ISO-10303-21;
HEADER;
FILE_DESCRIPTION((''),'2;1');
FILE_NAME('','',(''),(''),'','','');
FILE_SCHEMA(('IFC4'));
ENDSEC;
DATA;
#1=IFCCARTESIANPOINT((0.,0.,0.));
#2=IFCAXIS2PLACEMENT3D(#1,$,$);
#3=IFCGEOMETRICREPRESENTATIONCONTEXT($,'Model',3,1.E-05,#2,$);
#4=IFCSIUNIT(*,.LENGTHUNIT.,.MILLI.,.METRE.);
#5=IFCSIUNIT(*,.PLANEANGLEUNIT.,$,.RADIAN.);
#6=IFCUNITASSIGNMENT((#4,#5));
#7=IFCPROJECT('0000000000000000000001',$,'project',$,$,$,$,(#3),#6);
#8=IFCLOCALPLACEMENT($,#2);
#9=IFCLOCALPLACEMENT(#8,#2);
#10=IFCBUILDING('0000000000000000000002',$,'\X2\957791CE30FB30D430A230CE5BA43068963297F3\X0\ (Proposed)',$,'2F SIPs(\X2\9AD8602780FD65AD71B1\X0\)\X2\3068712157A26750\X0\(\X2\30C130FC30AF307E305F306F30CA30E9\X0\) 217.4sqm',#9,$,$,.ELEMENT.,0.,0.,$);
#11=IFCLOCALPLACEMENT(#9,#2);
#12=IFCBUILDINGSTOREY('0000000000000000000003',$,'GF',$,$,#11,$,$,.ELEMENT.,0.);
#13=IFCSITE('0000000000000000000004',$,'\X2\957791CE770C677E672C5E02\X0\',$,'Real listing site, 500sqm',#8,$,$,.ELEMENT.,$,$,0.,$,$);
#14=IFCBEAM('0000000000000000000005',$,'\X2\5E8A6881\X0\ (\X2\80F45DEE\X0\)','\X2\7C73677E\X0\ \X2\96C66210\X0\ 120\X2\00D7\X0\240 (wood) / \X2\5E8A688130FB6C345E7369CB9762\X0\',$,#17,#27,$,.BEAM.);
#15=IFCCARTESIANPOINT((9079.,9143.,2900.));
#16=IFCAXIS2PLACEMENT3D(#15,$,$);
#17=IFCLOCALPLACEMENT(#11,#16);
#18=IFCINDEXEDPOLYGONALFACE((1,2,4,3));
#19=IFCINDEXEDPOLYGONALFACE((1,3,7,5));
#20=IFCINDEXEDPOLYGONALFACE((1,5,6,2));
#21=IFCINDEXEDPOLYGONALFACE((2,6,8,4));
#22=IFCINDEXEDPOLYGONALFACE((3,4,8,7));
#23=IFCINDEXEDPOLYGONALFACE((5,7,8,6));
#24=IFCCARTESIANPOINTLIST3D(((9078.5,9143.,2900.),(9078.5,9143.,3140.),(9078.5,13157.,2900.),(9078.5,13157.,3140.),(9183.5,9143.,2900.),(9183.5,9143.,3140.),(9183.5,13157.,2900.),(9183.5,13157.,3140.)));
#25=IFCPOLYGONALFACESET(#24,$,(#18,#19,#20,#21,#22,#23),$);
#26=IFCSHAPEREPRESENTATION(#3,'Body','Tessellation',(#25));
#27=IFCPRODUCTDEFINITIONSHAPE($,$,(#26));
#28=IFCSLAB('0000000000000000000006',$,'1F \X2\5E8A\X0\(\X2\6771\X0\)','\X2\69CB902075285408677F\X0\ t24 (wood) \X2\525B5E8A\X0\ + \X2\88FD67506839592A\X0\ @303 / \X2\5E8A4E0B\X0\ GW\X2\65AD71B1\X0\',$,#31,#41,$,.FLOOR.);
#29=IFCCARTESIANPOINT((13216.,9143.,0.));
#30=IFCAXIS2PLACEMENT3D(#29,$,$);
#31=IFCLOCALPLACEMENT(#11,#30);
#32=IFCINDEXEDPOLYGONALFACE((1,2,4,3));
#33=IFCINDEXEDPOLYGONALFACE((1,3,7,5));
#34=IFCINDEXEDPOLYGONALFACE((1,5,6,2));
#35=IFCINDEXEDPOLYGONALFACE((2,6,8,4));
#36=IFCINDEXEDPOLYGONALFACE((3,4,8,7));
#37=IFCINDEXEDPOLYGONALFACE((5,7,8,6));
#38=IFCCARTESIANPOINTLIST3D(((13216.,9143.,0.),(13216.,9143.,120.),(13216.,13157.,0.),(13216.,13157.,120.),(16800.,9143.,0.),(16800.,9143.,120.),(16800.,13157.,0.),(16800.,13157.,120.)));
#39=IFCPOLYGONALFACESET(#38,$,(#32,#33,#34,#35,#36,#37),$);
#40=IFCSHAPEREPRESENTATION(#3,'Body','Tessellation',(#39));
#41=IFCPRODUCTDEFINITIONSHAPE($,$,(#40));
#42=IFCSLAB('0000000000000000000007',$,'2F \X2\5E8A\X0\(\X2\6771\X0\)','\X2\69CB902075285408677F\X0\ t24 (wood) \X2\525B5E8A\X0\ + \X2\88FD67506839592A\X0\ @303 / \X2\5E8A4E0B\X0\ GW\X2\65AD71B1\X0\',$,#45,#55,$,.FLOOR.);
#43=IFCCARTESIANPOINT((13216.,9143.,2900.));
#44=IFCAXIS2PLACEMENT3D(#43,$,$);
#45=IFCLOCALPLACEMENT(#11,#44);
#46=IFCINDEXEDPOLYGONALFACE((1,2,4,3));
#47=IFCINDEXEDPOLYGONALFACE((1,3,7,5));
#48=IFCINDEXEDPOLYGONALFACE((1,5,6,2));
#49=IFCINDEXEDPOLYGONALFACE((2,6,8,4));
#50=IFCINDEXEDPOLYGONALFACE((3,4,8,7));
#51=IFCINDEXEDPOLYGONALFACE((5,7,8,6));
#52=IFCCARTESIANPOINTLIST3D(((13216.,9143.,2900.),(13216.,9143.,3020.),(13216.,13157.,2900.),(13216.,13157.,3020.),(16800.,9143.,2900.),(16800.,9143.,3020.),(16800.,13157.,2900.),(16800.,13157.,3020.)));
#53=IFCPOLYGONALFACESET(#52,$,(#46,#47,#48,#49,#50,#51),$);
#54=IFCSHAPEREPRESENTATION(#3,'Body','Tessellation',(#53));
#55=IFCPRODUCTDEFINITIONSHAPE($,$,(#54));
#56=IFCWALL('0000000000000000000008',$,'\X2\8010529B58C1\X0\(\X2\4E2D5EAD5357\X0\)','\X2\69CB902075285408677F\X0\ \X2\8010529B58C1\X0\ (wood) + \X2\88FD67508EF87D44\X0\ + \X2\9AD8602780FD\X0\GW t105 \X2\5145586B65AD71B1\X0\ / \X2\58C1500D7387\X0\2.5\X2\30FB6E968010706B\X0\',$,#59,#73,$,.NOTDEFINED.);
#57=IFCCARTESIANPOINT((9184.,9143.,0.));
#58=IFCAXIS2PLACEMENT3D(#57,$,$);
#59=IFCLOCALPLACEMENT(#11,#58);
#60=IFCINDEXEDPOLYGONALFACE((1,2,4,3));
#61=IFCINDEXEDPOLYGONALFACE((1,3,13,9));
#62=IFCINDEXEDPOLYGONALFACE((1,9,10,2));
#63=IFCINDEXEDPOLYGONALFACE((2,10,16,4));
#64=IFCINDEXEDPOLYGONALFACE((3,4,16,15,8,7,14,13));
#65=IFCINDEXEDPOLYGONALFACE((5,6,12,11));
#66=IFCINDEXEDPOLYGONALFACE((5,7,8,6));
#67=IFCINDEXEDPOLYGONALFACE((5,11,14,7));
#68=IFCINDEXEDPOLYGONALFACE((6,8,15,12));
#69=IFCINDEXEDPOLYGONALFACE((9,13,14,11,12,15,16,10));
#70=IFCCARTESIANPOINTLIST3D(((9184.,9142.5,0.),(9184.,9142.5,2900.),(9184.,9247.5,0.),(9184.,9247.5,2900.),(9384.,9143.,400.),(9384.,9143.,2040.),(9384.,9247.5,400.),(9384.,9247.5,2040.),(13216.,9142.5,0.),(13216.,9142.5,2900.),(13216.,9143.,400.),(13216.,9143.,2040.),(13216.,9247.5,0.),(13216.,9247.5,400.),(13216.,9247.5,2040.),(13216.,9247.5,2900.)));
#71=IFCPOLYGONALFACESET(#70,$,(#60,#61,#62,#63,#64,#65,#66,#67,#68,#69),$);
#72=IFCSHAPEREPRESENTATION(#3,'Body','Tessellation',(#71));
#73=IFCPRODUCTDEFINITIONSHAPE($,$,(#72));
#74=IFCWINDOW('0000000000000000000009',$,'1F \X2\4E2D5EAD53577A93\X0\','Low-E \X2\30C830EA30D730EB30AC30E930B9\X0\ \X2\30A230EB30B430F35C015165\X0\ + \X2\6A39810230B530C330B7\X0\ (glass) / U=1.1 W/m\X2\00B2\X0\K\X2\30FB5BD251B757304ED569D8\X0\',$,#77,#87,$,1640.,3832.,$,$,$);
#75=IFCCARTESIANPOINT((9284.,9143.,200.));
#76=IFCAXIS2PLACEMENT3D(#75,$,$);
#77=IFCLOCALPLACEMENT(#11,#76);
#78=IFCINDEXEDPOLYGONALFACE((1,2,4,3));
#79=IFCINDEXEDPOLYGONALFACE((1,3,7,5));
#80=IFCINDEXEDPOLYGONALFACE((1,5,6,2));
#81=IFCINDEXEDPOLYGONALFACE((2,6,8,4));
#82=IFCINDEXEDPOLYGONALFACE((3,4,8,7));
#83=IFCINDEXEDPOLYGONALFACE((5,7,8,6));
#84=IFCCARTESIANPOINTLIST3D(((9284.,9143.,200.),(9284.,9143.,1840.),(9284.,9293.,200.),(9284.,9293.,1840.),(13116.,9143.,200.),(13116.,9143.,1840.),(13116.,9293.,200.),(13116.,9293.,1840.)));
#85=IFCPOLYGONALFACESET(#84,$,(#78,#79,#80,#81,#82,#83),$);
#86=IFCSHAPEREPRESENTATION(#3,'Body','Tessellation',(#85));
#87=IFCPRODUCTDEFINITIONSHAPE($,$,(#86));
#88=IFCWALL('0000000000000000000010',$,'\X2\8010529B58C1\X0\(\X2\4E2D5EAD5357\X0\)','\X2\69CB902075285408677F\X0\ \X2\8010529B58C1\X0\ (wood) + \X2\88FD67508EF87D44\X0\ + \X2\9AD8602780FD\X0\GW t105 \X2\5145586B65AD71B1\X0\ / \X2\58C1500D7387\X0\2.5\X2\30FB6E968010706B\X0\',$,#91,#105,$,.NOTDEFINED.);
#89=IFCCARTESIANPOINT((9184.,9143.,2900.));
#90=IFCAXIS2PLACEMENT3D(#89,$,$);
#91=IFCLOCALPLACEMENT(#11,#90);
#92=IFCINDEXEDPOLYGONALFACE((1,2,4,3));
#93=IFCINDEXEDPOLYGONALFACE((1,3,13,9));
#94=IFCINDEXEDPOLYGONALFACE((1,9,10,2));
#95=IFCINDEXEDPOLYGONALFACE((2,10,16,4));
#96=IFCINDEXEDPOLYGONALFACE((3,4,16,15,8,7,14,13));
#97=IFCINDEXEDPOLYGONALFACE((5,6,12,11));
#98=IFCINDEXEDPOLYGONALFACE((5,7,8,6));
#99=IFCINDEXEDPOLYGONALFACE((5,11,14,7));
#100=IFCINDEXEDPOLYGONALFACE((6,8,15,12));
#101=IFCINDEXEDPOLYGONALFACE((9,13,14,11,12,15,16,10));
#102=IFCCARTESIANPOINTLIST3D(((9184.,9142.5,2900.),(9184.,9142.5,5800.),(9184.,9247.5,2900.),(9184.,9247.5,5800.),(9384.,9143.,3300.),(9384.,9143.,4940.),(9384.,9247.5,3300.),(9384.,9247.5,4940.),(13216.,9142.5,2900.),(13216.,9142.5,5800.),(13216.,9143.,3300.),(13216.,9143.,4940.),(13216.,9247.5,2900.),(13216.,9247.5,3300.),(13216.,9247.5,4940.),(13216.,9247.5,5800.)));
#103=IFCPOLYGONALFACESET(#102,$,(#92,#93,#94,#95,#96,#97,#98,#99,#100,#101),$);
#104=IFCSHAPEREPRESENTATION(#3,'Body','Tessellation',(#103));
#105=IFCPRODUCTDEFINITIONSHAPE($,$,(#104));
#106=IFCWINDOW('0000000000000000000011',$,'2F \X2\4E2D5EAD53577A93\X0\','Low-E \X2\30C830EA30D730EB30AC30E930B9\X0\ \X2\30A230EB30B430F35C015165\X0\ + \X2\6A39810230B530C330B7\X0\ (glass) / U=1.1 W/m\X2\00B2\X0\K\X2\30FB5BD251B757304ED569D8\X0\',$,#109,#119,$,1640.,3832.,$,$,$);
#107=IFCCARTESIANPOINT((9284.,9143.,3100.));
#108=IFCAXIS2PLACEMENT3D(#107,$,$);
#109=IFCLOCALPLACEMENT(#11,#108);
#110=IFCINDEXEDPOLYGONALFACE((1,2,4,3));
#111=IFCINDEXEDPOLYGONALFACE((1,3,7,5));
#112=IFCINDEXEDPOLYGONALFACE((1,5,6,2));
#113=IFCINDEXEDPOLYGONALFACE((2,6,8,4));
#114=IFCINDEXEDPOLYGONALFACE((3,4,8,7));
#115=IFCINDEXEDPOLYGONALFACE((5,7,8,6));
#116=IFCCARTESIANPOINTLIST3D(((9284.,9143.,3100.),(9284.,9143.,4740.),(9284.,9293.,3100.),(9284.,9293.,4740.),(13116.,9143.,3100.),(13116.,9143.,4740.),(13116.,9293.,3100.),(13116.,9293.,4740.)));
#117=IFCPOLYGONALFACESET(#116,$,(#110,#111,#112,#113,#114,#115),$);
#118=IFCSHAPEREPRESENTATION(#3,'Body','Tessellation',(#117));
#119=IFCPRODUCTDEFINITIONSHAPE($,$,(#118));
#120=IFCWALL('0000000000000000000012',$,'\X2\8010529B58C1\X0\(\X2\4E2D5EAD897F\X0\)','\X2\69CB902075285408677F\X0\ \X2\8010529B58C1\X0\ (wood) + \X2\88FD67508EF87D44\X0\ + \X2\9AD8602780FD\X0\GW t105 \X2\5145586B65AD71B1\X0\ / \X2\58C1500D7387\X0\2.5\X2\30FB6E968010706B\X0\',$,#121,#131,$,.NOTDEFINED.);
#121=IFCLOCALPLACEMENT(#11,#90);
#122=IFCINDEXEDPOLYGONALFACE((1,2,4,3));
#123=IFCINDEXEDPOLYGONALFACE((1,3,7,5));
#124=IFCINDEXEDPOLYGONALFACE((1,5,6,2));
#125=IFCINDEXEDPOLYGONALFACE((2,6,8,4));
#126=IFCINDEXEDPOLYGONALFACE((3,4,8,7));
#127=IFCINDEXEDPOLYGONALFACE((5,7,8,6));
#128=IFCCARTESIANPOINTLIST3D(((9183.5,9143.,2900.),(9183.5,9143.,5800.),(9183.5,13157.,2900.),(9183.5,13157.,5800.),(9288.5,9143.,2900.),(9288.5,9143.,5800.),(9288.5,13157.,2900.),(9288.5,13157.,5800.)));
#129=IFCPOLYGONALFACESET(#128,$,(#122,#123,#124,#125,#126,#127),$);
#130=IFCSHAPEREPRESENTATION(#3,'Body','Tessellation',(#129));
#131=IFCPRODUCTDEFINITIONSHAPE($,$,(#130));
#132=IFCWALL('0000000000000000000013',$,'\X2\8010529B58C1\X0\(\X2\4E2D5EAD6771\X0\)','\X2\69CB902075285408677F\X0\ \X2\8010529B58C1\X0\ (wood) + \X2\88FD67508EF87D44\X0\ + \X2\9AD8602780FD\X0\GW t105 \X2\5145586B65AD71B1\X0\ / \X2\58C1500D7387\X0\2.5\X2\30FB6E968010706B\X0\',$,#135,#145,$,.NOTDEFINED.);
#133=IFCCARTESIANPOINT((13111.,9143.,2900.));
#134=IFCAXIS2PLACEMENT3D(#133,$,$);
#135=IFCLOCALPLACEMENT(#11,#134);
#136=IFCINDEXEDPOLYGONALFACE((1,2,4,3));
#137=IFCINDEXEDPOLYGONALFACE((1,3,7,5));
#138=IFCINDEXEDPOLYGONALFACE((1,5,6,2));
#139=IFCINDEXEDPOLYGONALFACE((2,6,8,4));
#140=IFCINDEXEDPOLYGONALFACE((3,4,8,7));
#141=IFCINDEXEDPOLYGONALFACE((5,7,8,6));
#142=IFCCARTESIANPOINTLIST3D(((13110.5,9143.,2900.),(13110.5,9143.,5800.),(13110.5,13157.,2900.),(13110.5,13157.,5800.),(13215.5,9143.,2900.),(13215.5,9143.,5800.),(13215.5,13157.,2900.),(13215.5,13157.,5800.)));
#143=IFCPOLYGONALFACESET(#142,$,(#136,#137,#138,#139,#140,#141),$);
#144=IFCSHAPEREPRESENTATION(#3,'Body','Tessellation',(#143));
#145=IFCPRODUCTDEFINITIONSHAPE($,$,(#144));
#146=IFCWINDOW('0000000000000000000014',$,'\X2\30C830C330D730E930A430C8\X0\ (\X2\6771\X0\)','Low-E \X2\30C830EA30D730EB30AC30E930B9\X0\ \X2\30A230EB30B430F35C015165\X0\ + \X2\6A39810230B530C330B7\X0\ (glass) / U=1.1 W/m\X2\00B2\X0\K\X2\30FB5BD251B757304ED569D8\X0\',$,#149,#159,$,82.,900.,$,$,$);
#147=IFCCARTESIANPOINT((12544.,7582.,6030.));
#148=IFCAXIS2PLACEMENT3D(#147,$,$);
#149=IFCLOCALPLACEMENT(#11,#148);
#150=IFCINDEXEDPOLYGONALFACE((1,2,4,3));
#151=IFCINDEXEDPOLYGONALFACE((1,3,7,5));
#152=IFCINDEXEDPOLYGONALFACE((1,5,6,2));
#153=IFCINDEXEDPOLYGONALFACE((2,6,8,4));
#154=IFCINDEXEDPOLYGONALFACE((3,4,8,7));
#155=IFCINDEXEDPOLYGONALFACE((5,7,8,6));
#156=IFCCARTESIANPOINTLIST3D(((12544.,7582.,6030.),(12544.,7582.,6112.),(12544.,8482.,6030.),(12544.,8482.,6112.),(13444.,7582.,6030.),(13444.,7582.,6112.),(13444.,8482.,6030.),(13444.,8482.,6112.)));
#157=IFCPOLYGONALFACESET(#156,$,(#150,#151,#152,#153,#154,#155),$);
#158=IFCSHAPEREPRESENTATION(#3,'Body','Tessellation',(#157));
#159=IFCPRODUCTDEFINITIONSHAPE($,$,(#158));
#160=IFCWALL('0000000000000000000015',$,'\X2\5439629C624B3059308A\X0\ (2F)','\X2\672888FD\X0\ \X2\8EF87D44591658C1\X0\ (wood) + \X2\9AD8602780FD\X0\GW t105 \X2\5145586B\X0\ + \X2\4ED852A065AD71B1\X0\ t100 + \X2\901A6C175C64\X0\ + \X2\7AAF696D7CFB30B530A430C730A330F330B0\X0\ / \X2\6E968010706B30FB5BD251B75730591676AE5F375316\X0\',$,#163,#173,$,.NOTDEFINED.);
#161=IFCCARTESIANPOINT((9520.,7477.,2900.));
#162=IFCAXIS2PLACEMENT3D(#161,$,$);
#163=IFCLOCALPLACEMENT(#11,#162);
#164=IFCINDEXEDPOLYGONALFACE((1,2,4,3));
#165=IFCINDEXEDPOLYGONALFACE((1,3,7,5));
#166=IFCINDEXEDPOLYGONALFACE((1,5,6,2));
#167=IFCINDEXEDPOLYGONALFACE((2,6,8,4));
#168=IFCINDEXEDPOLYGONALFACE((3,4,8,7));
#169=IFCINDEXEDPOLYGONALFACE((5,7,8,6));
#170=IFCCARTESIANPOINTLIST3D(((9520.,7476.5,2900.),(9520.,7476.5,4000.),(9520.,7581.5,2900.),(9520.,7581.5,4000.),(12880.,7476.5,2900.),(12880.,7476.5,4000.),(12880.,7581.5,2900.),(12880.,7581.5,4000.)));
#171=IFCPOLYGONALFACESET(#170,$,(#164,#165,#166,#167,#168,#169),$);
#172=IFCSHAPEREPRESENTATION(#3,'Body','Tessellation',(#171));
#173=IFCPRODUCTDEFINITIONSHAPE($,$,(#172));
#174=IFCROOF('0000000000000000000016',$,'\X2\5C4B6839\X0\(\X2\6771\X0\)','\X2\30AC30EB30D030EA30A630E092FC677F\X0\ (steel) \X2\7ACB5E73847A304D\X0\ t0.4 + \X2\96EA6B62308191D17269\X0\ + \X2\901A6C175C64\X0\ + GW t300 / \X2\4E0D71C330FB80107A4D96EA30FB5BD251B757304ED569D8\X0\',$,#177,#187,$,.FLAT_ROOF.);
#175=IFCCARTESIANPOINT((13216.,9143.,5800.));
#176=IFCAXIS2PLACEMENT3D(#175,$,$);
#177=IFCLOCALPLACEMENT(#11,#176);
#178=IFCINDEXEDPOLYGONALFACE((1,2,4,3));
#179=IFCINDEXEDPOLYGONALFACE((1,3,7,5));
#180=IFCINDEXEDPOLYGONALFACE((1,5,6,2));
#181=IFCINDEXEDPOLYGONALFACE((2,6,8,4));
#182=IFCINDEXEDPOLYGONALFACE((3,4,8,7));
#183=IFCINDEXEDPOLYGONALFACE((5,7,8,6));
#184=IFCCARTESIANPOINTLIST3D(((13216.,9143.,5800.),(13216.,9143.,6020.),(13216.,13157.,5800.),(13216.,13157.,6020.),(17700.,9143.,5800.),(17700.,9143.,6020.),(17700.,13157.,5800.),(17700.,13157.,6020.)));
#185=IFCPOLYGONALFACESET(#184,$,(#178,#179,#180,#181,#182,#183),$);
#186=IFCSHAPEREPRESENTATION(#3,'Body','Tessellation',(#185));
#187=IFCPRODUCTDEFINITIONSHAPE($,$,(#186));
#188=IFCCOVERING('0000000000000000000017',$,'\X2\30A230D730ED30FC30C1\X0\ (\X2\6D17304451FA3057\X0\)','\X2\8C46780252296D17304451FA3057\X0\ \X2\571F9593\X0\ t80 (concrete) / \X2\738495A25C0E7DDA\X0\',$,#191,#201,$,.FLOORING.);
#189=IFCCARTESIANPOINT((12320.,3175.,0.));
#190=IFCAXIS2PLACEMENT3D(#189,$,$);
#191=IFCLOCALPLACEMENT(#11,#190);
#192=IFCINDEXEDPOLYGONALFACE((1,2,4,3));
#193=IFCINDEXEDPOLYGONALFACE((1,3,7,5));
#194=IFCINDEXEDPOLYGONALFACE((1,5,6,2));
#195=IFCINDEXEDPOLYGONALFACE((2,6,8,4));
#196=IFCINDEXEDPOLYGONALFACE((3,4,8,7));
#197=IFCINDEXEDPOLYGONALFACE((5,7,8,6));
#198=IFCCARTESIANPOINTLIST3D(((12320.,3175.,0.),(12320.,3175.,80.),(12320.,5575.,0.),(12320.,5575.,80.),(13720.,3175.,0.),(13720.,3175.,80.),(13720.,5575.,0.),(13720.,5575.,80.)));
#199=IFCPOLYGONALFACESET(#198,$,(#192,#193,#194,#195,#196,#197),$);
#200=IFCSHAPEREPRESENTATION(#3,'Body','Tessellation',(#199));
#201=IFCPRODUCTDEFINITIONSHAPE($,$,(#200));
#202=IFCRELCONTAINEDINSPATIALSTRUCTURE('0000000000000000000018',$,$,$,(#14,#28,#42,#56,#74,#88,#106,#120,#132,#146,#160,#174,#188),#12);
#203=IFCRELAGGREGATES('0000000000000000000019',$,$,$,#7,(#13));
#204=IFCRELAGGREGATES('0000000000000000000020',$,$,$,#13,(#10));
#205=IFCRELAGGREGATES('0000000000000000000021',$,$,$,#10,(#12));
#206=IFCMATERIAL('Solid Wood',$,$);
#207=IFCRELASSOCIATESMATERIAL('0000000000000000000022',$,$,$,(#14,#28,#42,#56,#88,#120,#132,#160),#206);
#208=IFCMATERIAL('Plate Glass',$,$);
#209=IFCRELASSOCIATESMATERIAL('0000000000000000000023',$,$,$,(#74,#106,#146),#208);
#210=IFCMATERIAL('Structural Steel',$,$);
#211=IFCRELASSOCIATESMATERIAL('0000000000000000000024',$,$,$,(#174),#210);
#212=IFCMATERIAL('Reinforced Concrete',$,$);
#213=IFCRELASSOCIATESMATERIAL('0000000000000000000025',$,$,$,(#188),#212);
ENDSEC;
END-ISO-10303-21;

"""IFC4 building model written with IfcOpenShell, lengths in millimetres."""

from ifc_helpers import new_model, si_unit, frame, frame_2d, origin, place, context, project, spatial, rectangle, extrude, material, element, fill, save


model = new_model("IFC4")

# Units and contexts
model_context = context("Model", 3, precision=1e-05, world=origin())
ifc_project = project(units=[si_unit("LENGTHUNIT", "METRE", prefix="MILLI"), si_unit("PLANEANGLEUNIT", "RADIAN")], contexts=[model_context])

# Site, building, storey
site_placement = place(None, origin())
site = spatial("IfcSite", under=ifc_project, at=site_placement, Name="長野県松本市", ObjectType="Real listing site, 500sqm", CompositionType="ELEMENT", RefElevation=0.0)
building_placement = place(site_placement, origin())
building = spatial("IfcBuilding", under=site, at=building_placement, Name="長野・ピアノ室と防音 (Proposed)", ObjectType="2F SIPs(高性能断熱)と無垢材(チークまたはナラ) 217.4sqm", CompositionType="ELEMENT", ElevationOfRefHeight=0.0, ElevationOfTerrain=0.0)
storey_placement = place(building_placement, origin())
storey = spatial("IfcBuildingStorey", under=building, at=storey_placement, Name="GF", CompositionType="ELEMENT", Elevation=0.0)

# Shared definitions
ifc_material_1 = material(Name="Solid Wood")

# Beam
beam_placement = place(storey_placement, frame((9079.0, 9143.0, 2900.0)))
element("IfcBeam", 1, at=beam_placement, inside=storey, material=ifc_material_1, Name="床梁 (胴差)", Description="米松 集成 120×240 (wood) / 床梁・水平構面", PredefinedType="BEAM", context=model_context, shape_type="SweptSolid", body=[
    extrude(rectangle(XDim=105.0, YDim=4014.0, at=frame_2d((52.0, 2007.0))), frame((9079.0, 9143.0, 2900.0)), (0.0, 0.0, 1.0), 240.0),
])

# Slabs
slab_1_placement = place(storey_placement, frame((13216.0, 9143.0, 0.0)))
element("IfcSlab", 2, at=slab_1_placement, inside=storey, material=ifc_material_1, Name="1F 床(東)", Description="構造用合板 t24 (wood) 剛床 + 製材根太 @303 / 床下 GW断熱", PredefinedType="FLOOR", context=model_context, shape_type="SweptSolid", body=[
    extrude(rectangle(XDim=3584.0, YDim=4014.0, at=frame_2d((1792.0, 2007.0))), frame((13216.0, 9143.0, 0.0)), (0.0, 0.0, 1.0), 120.0),
])
slab_2_placement = place(storey_placement, frame((13216.0, 9143.0, 2900.0)))
element("IfcSlab", 3, at=slab_2_placement, inside=storey, material=ifc_material_1, Name="2F 床(東)", Description="構造用合板 t24 (wood) 剛床 + 製材根太 @303 / 床下 GW断熱", PredefinedType="FLOOR", context=model_context, shape_type="SweptSolid", body=[
    extrude(rectangle(XDim=3584.0, YDim=4014.0, at=frame_2d((1792.0, 2007.0))), frame((13216.0, 9143.0, 2900.0)), (0.0, 0.0, 1.0), 120.0),
])

# Wall, opening, window
wall_1_placement = place(storey_placement, frame((9184.0, 9143.0, 0.0)))
wall_1 = element("IfcWall", 4, at=wall_1_placement, inside=storey, material=ifc_material_1, Name="耐力壁(中庭南)", Description="構造用合板 耐力壁 (wood) + 製材軸組 + 高性能GW t105 充填断熱 / 壁倍率2.5・準耐火", PredefinedType="NOTDEFINED", context=model_context, shape_type="SweptSolid", body=[
    extrude(rectangle(XDim=4032.0, YDim=105.0, at=frame_2d((2016.0, 52.0))), frame((9184.0, 9143.0, 0.0)), (0.0, 0.0, 1.0), 2900.0),
])
opening_1_placement = place(storey_placement, frame((9284.0, 9143.0, 200.0)))
opening_1 = element("IfcOpeningElement", 5, at=opening_1_placement, cuts=wall_1, PredefinedType="NOTDEFINED", context=model_context, shape_type="SweptSolid", body=[
    extrude(rectangle(XDim=3832.0, YDim=150.0, at=frame_2d((1916.0, 75.0))), frame((9284.0, 9143.0, 200.0)), (0.0, 0.0, 1.0), 1640.0),
])
ifc_material_2 = material(Name="Plate Glass")
window_1_placement = place(storey_placement, frame((9284.0, 9143.0, 200.0)))
window_1 = element("IfcWindow", 6, at=window_1_placement, inside=storey, material=ifc_material_2, Name="1F 中庭南窓", Description="Low-E トリプルガラス アルゴン封入 + 樹脂サッシ (glass) / U=1.1 W/m²K・寒冷地仕様", OverallHeight=1640.0, OverallWidth=3832.0, context=model_context, shape_type="SweptSolid", body=[
    extrude(rectangle(XDim=3832.0, YDim=150.0, at=frame_2d((1916.0, 75.0))), frame((9284.0, 9143.0, 200.0)), (0.0, 0.0, 1.0), 1640.0),
])
fill(opening_1, window_1)

# Wall, opening, window
wall_2_placement = place(storey_placement, frame((9184.0, 9143.0, 2900.0)))
wall_2 = element("IfcWall", 7, at=wall_2_placement, inside=storey, material=ifc_material_1, Name="耐力壁(中庭南)", Description="構造用合板 耐力壁 (wood) + 製材軸組 + 高性能GW t105 充填断熱 / 壁倍率2.5・準耐火", PredefinedType="NOTDEFINED", context=model_context, shape_type="SweptSolid", body=[
    extrude(rectangle(XDim=4032.0, YDim=105.0, at=frame_2d((2016.0, 52.0))), frame((9184.0, 9143.0, 2900.0)), (0.0, 0.0, 1.0), 2900.0),
])
opening_2_placement = place(storey_placement, frame((9284.0, 9143.0, 3100.0)))
opening_2 = element("IfcOpeningElement", 8, at=opening_2_placement, cuts=wall_2, PredefinedType="NOTDEFINED", context=model_context, shape_type="SweptSolid", body=[
    extrude(rectangle(XDim=3832.0, YDim=150.0, at=frame_2d((1916.0, 75.0))), frame((9284.0, 9143.0, 3100.0)), (0.0, 0.0, 1.0), 1640.0),
])
window_2_placement = place(storey_placement, frame((9284.0, 9143.0, 3100.0)))
window_2 = element("IfcWindow", 9, at=window_2_placement, inside=storey, material=ifc_material_2, Name="2F 中庭南窓", Description="Low-E トリプルガラス アルゴン封入 + 樹脂サッシ (glass) / U=1.1 W/m²K・寒冷地仕様", OverallHeight=1640.0, OverallWidth=3832.0, context=model_context, shape_type="SweptSolid", body=[
    extrude(rectangle(XDim=3832.0, YDim=150.0, at=frame_2d((1916.0, 75.0))), frame((9284.0, 9143.0, 3100.0)), (0.0, 0.0, 1.0), 1640.0),
])
fill(opening_2, window_2)

# Walls
wall_3_placement = place(storey_placement, frame((9184.0, 9143.0, 2900.0)))
element("IfcWall", 10, at=wall_3_placement, inside=storey, material=ifc_material_1, Name="耐力壁(中庭西)", Description="構造用合板 耐力壁 (wood) + 製材軸組 + 高性能GW t105 充填断熱 / 壁倍率2.5・準耐火", PredefinedType="NOTDEFINED", context=model_context, shape_type="SweptSolid", body=[
    extrude(rectangle(XDim=105.0, YDim=4014.0, at=frame_2d((52.0, 2007.0))), frame((9184.0, 9143.0, 2900.0)), (0.0, 0.0, 1.0), 2900.0),
])
wall_4_placement = place(storey_placement, frame((13111.0, 9143.0, 2900.0)))
element("IfcWall", 11, at=wall_4_placement, inside=storey, material=ifc_material_1, Name="耐力壁(中庭東)", Description="構造用合板 耐力壁 (wood) + 製材軸組 + 高性能GW t105 充填断熱 / 壁倍率2.5・準耐火", PredefinedType="NOTDEFINED", context=model_context, shape_type="SweptSolid", body=[
    extrude(rectangle(XDim=105.0, YDim=4014.0, at=frame_2d((52.0, 2007.0))), frame((13111.0, 9143.0, 2900.0)), (0.0, 0.0, 1.0), 2900.0),
])

# Window
window_3_placement = place(storey_placement, frame((12544.0, 7582.0, 6030.0)))
element("IfcWindow", 12, at=window_3_placement, inside=storey, material=ifc_material_2, Name="トップライト (東)", Description="Low-E トリプルガラス アルゴン封入 + 樹脂サッシ (glass) / U=1.1 W/m²K・寒冷地仕様", OverallHeight=82.0, OverallWidth=900.0, context=model_context, shape_type="SweptSolid", body=[
    extrude(rectangle(XDim=900.0, YDim=900.0, at=frame_2d((450.0, 450.0))), frame((12544.0, 7582.0, 6030.0)), (0.0, 0.0, 1.0), 82.0),
])

# Wall
wall_5_placement = place(storey_placement, frame((9520.0, 7477.0, 2900.0)))
element("IfcWall", 13, at=wall_5_placement, inside=storey, material=ifc_material_1, Name="吹抜手すり (2F)", Description="木製 軸組外壁 (wood) + 高性能GW t105 充填 + 付加断熱 t100 + 通気層 + 窯業系サイディング / 準耐火・寒冷地外皮強化", PredefinedType="NOTDEFINED", context=model_context, shape_type="SweptSolid", body=[
    extrude(rectangle(XDim=3360.0, YDim=105.0, at=frame_2d((1680.0, 52.0))), frame((9520.0, 7477.0, 2900.0)), (0.0, 0.0, 1.0), 1100.0),
])

# Roof
ifc_material_3 = material(Name="Structural Steel")
roof_placement = place(storey_placement, frame((13216.0, 9143.0, 5800.0)))
element("IfcRoof", 14, at=roof_placement, inside=storey, material=ifc_material_3, Name="屋根(東)", Description="ガルバリウム鋼板 (steel) 立平葺き t0.4 + 雪止め金物 + 通気層 + GW t300 / 不燃・耐積雪・寒冷地仕様", PredefinedType="FLAT_ROOF", context=model_context, shape_type="SweptSolid", body=[
    extrude(rectangle(XDim=4484.0, YDim=4014.0, at=frame_2d((2242.0, 2007.0))), frame((13216.0, 9143.0, 5800.0)), (0.0, 0.0, 1.0), 220.0),
])

# Covering
ifc_material_4 = material(Name="Reinforced Concrete")
covering_placement = place(storey_placement, frame((12320.0, 3175.0, 0.0)))
element("IfcCovering", 15, at=covering_placement, inside=storey, material=ifc_material_4, Name="アプローチ (洗い出し)", Description="豆砂利洗い出し 土間 t80 (concrete) / 玄関導線", PredefinedType="FLOORING", context=model_context, shape_type="SweptSolid", body=[
    extrude(rectangle(XDim=1400.0, YDim=2400.0, at=frame_2d((700.0, 1200.0))), frame((12320.0, 3175.0, 0.0)), (0.0, 0.0, 1.0), 80.0),
])

save(model, "model.ifc")
